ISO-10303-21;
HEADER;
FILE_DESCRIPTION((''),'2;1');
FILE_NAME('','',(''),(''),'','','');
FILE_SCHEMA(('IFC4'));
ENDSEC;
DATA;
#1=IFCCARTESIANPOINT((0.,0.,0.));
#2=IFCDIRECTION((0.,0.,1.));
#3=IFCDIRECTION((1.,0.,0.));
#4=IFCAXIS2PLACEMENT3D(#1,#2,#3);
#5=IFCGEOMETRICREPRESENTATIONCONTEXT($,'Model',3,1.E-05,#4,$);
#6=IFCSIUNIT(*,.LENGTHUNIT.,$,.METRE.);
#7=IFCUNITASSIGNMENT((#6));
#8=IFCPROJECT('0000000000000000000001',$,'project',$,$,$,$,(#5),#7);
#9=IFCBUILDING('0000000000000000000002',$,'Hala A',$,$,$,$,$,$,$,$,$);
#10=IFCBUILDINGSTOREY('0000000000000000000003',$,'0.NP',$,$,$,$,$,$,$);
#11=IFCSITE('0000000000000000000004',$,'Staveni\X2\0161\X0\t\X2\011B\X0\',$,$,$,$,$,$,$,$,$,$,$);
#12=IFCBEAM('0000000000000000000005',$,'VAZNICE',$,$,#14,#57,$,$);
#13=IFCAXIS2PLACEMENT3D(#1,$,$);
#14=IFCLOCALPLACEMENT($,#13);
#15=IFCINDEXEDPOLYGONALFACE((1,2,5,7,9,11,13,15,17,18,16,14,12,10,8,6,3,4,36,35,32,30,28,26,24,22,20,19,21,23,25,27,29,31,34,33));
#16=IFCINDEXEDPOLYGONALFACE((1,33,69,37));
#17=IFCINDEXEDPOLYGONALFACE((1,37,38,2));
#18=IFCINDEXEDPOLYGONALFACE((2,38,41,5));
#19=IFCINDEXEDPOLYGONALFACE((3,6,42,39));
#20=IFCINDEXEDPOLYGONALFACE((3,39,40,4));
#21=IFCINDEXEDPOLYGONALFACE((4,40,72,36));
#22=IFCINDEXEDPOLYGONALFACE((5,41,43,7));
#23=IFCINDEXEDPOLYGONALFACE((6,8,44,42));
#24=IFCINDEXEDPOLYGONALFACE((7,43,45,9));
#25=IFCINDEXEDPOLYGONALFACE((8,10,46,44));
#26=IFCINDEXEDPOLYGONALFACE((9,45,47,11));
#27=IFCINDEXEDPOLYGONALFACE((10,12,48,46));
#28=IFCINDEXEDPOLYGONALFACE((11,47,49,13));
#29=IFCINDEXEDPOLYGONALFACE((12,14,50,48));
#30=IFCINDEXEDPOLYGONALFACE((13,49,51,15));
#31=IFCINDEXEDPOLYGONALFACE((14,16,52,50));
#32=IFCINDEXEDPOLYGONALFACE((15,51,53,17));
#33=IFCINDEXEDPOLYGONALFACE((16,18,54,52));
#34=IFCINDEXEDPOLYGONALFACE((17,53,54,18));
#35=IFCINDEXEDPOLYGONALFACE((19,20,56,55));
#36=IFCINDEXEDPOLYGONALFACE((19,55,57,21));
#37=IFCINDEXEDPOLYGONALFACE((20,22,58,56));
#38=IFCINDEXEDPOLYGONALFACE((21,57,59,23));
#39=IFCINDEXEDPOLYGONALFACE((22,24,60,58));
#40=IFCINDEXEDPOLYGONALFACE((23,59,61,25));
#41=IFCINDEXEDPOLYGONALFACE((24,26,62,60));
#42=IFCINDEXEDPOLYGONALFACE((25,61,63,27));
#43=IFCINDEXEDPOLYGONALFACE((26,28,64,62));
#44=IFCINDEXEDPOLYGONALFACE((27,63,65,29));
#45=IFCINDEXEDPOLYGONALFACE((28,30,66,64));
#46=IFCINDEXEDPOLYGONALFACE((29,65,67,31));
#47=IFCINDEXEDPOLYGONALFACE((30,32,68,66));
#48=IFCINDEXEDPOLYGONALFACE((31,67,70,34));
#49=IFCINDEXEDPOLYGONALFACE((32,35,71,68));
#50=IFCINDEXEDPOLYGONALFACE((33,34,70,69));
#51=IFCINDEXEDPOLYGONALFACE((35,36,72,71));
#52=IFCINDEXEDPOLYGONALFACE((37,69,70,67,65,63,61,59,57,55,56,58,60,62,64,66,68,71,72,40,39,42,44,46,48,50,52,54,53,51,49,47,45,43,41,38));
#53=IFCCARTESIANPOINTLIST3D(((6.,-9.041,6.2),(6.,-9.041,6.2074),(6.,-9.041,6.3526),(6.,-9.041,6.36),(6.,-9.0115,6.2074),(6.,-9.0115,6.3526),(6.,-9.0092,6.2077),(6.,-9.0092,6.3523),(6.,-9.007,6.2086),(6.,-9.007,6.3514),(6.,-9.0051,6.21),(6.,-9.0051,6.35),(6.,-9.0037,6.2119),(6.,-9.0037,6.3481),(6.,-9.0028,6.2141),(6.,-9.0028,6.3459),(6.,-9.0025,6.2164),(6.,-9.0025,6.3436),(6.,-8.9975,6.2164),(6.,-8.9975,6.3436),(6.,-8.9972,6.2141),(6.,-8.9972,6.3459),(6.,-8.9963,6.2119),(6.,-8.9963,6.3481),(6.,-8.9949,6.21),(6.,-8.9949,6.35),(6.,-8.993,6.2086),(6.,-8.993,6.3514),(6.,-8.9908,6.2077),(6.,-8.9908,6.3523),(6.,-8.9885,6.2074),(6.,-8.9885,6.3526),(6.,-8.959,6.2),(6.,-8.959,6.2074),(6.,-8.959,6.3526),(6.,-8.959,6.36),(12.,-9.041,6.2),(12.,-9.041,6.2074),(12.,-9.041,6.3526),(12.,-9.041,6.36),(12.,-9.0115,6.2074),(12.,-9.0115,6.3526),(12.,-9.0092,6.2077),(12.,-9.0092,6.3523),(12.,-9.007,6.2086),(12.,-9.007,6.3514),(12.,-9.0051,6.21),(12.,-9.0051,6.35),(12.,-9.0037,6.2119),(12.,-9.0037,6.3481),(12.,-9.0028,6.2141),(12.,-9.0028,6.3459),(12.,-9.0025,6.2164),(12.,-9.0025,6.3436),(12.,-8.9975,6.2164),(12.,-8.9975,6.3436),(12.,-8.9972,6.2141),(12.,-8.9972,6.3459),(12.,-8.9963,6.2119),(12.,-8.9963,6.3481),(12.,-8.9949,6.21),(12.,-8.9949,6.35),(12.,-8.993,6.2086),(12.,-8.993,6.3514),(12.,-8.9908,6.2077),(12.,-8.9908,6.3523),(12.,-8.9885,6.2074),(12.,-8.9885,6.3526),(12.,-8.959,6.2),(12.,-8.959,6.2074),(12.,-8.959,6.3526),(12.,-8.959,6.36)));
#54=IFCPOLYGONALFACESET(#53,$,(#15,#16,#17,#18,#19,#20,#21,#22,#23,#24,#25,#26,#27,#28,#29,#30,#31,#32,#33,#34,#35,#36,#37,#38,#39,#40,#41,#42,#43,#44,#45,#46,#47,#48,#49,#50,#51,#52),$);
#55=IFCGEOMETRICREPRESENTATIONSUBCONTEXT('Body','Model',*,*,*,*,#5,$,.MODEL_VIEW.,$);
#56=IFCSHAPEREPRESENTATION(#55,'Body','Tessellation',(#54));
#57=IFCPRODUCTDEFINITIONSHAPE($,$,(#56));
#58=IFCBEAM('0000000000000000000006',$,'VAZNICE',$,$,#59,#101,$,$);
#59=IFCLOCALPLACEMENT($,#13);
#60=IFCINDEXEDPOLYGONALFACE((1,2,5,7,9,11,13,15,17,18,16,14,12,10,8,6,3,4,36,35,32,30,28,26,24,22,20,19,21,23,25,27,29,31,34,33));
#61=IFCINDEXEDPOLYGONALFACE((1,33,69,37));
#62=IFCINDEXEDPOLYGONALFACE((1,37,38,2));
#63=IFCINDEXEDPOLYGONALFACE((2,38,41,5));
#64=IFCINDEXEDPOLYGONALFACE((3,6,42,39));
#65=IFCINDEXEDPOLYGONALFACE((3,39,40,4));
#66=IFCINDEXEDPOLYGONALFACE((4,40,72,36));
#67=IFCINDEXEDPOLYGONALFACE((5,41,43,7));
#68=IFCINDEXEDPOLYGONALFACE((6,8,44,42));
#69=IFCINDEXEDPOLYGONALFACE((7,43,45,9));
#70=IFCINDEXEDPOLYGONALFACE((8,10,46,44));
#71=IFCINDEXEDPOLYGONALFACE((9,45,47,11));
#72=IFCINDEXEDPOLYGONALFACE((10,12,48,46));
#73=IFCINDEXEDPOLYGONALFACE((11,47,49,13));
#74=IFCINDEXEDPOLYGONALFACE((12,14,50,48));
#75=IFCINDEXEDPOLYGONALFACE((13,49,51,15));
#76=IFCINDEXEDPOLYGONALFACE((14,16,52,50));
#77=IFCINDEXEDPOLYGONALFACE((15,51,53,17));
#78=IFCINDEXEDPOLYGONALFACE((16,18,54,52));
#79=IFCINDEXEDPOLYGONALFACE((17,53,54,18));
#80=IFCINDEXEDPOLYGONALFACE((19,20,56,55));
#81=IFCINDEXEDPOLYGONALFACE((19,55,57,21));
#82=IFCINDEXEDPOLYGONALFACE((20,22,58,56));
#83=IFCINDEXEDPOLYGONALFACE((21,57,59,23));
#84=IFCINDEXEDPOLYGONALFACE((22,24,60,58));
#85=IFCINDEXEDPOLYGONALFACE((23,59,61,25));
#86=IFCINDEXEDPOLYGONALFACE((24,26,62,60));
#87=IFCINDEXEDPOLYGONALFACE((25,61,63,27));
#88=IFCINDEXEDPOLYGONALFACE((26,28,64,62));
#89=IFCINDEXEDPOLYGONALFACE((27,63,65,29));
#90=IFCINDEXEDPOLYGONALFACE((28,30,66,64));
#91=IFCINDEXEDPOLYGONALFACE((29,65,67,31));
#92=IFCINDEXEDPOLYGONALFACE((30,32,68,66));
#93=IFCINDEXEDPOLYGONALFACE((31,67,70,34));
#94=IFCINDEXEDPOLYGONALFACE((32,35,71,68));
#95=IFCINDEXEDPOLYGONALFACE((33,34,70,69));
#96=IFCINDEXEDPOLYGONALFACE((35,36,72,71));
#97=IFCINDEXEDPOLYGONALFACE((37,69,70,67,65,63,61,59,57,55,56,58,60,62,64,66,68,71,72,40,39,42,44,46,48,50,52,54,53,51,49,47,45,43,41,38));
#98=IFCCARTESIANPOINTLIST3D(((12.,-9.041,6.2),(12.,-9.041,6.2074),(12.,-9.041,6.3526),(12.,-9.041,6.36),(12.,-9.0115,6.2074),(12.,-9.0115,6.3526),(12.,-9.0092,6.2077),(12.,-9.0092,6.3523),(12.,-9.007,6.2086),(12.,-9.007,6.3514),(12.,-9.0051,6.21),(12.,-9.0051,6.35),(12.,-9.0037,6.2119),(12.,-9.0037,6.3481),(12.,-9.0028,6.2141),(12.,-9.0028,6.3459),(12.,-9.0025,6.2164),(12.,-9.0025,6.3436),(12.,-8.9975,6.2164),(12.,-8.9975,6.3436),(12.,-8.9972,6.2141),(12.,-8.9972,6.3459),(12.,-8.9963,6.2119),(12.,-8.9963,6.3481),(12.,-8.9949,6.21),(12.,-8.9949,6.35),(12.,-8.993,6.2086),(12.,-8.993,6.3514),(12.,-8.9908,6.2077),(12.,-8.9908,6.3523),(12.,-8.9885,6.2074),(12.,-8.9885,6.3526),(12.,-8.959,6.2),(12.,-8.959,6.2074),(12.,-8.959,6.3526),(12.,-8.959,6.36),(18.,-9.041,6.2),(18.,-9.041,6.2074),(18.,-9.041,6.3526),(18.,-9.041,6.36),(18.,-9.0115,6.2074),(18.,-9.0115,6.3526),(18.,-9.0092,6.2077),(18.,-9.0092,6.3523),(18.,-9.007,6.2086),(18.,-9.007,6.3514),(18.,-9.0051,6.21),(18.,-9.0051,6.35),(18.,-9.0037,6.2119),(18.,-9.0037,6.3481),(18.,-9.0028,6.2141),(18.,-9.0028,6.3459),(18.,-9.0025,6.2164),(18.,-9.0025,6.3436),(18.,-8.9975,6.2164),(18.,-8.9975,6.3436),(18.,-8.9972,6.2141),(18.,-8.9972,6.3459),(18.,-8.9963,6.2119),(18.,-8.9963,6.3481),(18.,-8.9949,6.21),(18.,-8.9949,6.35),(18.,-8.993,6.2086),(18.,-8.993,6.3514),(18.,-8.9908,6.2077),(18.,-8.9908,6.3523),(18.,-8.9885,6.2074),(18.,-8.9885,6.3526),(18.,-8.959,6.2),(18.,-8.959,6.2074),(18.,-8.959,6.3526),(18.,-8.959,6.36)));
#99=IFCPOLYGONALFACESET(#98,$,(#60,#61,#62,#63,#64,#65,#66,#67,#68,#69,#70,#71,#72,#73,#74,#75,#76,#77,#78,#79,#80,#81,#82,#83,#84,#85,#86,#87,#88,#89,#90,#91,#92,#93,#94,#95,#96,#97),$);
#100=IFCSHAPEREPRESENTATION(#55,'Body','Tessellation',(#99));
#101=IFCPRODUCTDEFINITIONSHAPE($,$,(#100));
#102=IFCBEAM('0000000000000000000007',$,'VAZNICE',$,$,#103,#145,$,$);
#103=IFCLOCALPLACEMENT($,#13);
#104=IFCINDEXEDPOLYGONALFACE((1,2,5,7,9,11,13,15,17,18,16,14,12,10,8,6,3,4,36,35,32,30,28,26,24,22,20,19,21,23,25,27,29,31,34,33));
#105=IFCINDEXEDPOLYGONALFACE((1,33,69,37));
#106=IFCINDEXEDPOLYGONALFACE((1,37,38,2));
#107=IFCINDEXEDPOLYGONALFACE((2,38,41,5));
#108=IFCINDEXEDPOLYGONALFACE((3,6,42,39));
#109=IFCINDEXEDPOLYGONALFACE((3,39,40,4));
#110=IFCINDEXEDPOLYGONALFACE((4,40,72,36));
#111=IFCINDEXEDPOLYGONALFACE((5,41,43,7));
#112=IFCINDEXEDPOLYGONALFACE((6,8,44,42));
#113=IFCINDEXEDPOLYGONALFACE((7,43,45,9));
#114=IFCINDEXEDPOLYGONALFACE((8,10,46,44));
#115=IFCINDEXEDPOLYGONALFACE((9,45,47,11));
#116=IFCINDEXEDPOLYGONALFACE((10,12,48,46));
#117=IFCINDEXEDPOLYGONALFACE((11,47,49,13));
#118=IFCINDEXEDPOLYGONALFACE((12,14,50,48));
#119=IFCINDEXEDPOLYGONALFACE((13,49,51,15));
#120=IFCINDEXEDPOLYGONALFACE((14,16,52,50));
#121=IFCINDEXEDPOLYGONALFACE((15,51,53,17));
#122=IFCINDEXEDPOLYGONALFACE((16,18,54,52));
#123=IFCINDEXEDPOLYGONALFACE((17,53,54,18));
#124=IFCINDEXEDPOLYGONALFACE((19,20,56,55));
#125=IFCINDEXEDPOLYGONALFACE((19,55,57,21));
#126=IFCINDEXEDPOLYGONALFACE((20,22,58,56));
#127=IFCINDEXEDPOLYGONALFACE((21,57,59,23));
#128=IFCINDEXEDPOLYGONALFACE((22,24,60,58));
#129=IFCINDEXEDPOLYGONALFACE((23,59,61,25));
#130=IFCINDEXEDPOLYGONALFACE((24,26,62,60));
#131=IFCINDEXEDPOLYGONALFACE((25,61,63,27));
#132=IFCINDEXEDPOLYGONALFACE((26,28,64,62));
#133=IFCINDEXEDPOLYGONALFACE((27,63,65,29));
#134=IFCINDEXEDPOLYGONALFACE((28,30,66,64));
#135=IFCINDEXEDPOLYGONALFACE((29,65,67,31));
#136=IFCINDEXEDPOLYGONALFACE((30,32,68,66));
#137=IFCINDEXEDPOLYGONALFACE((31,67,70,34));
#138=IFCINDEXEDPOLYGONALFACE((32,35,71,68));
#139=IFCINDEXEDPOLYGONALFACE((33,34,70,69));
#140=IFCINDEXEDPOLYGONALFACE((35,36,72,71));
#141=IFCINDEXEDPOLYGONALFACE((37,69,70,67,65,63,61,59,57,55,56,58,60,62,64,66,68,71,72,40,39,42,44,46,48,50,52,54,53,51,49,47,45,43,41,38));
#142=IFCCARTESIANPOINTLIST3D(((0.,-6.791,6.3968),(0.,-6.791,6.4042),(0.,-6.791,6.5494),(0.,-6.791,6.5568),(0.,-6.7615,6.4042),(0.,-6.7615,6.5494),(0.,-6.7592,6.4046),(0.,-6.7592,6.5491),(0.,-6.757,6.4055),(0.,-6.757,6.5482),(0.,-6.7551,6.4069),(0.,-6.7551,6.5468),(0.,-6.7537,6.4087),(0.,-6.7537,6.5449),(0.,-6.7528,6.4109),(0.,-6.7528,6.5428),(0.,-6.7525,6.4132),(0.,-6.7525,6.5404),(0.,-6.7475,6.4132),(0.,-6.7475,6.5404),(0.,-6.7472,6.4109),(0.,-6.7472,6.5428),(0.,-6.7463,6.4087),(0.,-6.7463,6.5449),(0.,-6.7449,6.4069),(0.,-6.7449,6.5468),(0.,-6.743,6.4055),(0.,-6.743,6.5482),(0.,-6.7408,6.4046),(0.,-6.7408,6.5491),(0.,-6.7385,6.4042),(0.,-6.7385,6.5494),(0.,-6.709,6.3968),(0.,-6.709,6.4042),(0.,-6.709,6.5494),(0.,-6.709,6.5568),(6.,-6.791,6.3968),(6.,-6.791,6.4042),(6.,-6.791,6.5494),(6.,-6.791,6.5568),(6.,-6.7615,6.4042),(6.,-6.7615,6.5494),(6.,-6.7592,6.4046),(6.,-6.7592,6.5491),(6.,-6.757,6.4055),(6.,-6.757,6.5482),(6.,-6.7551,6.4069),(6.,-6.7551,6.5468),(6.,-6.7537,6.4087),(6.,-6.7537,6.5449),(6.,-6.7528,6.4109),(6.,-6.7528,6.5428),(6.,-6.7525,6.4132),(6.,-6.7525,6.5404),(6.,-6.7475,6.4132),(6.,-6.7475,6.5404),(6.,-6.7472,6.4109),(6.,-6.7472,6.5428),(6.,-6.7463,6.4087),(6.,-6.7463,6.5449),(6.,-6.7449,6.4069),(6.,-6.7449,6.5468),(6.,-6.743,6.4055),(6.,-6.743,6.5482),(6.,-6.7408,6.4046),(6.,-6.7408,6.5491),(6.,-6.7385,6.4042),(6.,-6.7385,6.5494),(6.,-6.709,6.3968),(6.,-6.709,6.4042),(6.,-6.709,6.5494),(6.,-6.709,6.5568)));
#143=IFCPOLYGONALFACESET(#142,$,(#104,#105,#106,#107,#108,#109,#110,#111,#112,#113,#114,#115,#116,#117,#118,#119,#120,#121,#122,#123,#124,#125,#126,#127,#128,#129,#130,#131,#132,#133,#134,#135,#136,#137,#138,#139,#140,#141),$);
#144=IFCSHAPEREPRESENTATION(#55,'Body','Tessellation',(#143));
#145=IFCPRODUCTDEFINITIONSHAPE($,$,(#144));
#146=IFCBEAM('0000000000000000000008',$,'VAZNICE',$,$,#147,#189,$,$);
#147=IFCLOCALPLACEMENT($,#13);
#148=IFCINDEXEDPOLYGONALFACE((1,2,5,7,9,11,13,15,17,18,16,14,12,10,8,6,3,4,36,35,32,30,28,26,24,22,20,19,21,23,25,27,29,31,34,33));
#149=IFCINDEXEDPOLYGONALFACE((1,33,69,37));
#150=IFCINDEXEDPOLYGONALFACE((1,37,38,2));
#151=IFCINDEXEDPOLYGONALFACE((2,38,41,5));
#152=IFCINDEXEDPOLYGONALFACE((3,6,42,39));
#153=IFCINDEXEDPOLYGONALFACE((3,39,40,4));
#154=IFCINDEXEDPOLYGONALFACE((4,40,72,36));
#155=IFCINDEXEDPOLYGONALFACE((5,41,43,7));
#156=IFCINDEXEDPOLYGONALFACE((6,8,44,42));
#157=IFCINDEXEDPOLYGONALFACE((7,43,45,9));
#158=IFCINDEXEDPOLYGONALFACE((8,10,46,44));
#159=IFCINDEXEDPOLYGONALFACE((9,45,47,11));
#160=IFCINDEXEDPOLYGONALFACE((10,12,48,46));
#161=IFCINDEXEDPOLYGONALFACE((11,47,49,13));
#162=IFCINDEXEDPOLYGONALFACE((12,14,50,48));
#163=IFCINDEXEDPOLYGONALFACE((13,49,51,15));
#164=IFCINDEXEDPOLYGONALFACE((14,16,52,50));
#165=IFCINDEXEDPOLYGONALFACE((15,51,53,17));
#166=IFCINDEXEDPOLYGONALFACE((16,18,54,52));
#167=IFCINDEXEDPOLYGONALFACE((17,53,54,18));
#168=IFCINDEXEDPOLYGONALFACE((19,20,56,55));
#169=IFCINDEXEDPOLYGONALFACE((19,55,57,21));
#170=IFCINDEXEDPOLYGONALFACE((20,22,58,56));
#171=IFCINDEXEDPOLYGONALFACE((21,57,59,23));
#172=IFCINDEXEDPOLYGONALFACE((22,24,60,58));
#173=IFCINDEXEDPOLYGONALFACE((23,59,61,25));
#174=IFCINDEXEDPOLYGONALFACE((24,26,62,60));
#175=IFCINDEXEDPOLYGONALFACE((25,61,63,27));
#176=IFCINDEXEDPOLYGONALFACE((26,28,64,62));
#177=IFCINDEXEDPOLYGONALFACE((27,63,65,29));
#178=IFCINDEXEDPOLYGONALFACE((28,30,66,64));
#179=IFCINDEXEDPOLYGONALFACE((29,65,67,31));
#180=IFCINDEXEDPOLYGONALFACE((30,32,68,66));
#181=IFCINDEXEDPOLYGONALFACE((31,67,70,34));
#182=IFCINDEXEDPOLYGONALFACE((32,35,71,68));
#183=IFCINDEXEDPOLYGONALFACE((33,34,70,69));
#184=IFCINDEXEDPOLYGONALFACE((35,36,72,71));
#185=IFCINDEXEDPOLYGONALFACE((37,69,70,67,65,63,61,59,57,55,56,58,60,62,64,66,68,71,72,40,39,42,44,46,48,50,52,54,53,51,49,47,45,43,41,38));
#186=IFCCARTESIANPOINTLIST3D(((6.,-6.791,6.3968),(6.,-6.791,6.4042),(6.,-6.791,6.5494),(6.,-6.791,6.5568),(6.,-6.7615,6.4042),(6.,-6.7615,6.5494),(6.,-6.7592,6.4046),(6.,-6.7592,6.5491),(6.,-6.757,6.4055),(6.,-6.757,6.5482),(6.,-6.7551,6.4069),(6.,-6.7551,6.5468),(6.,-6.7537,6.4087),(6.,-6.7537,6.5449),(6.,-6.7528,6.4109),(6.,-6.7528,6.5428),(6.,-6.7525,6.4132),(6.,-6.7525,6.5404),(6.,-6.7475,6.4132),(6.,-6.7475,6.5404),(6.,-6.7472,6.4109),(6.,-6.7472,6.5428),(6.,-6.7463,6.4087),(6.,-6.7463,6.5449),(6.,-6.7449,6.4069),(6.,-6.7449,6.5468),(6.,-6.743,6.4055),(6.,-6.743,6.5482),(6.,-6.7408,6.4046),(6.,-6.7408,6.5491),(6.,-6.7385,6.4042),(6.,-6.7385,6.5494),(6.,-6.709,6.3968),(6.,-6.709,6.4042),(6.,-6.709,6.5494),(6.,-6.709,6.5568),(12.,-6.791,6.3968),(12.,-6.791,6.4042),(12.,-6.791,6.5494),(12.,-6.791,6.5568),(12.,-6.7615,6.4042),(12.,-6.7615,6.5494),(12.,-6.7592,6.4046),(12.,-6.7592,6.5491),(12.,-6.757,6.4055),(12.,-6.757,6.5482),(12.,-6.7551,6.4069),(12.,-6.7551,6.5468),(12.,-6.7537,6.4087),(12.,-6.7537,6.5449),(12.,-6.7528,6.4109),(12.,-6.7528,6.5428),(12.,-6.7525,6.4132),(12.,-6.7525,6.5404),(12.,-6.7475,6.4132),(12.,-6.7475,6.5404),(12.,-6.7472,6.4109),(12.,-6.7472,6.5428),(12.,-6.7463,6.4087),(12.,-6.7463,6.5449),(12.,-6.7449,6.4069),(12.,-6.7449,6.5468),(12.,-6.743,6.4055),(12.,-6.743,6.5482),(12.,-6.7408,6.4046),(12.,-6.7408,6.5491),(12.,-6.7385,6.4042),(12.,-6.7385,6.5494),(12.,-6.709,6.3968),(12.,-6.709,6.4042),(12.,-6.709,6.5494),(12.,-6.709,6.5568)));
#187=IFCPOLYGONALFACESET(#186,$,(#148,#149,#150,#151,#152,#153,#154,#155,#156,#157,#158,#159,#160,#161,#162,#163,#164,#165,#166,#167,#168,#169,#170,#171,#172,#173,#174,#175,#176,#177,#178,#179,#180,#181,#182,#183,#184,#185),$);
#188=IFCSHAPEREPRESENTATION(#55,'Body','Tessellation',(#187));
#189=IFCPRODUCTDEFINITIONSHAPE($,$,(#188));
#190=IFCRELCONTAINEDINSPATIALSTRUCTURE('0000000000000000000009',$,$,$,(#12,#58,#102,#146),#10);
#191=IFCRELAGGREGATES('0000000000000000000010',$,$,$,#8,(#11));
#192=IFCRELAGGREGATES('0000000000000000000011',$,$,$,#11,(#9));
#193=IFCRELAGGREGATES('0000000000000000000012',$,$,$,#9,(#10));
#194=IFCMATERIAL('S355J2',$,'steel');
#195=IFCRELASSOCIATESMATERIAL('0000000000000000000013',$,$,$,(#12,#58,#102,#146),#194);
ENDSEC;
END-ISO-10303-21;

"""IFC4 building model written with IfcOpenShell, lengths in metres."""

from ifc_helpers import new_model, si_unit, frame, origin_with_axes, place, context, subcontext, project, spatial, i_section, extrude, material, element, save


model = new_model("IFC4")

# Units and contexts
model_context = context("Model", 3, precision=1e-05, world=origin_with_axes())
body_context = subcontext(model_context, "Body", "Model", "MODEL_VIEW")
ifc_project = project(units=[si_unit("LENGTHUNIT", "METRE")], contexts=[model_context])

# Site, building, storey
site = spatial("IfcSite", under=ifc_project, Name="Staveniště")
building = spatial("IfcBuilding", under=site, Name="Hala A")
storey = spatial("IfcBuildingStorey", under=building, Name="0.NP")

# Shared definitions
ifc_material = material(Name="S355J2", Category="steel")

# Beams
for number, where, z_axis, x_axis, name in (
    (1, (6.0, -9.0, 6.28), (1.0, 0.0, 0.0), (0.0, 1.0, 0.0), "VAZNICE"),
    (2, (12.0, -9.0, 6.28), (1.0, 0.0, 0.0), (0.0, 1.0, 0.0), "VAZNICE"),
    (3, (0.0, -6.75, 6.4768), (1.0, 0.0, 0.0), (0.0, 1.0, 0.0), "VAZNICE"),
    (4, (6.0, -6.75, 6.4768), (1.0, 0.0, 0.0), (0.0, 1.0, 0.0), "VAZNICE"),
):
    element("IfcBeam", number, at=place(None, frame(where, z_axis=z_axis, x_axis=x_axis)), inside=storey, material=ifc_material, Name=name, context=body_context, shape_type="SweptSolid", body=[
        extrude(i_section(OverallWidth=0.082, OverallDepth=0.16, WebThickness=0.005, FlangeThickness=0.0074, FilletRadius=0.009), origin_with_axes(), (0.0, 0.0, 1.0), 6.0),
    ])

save(model, "model.ifc")
